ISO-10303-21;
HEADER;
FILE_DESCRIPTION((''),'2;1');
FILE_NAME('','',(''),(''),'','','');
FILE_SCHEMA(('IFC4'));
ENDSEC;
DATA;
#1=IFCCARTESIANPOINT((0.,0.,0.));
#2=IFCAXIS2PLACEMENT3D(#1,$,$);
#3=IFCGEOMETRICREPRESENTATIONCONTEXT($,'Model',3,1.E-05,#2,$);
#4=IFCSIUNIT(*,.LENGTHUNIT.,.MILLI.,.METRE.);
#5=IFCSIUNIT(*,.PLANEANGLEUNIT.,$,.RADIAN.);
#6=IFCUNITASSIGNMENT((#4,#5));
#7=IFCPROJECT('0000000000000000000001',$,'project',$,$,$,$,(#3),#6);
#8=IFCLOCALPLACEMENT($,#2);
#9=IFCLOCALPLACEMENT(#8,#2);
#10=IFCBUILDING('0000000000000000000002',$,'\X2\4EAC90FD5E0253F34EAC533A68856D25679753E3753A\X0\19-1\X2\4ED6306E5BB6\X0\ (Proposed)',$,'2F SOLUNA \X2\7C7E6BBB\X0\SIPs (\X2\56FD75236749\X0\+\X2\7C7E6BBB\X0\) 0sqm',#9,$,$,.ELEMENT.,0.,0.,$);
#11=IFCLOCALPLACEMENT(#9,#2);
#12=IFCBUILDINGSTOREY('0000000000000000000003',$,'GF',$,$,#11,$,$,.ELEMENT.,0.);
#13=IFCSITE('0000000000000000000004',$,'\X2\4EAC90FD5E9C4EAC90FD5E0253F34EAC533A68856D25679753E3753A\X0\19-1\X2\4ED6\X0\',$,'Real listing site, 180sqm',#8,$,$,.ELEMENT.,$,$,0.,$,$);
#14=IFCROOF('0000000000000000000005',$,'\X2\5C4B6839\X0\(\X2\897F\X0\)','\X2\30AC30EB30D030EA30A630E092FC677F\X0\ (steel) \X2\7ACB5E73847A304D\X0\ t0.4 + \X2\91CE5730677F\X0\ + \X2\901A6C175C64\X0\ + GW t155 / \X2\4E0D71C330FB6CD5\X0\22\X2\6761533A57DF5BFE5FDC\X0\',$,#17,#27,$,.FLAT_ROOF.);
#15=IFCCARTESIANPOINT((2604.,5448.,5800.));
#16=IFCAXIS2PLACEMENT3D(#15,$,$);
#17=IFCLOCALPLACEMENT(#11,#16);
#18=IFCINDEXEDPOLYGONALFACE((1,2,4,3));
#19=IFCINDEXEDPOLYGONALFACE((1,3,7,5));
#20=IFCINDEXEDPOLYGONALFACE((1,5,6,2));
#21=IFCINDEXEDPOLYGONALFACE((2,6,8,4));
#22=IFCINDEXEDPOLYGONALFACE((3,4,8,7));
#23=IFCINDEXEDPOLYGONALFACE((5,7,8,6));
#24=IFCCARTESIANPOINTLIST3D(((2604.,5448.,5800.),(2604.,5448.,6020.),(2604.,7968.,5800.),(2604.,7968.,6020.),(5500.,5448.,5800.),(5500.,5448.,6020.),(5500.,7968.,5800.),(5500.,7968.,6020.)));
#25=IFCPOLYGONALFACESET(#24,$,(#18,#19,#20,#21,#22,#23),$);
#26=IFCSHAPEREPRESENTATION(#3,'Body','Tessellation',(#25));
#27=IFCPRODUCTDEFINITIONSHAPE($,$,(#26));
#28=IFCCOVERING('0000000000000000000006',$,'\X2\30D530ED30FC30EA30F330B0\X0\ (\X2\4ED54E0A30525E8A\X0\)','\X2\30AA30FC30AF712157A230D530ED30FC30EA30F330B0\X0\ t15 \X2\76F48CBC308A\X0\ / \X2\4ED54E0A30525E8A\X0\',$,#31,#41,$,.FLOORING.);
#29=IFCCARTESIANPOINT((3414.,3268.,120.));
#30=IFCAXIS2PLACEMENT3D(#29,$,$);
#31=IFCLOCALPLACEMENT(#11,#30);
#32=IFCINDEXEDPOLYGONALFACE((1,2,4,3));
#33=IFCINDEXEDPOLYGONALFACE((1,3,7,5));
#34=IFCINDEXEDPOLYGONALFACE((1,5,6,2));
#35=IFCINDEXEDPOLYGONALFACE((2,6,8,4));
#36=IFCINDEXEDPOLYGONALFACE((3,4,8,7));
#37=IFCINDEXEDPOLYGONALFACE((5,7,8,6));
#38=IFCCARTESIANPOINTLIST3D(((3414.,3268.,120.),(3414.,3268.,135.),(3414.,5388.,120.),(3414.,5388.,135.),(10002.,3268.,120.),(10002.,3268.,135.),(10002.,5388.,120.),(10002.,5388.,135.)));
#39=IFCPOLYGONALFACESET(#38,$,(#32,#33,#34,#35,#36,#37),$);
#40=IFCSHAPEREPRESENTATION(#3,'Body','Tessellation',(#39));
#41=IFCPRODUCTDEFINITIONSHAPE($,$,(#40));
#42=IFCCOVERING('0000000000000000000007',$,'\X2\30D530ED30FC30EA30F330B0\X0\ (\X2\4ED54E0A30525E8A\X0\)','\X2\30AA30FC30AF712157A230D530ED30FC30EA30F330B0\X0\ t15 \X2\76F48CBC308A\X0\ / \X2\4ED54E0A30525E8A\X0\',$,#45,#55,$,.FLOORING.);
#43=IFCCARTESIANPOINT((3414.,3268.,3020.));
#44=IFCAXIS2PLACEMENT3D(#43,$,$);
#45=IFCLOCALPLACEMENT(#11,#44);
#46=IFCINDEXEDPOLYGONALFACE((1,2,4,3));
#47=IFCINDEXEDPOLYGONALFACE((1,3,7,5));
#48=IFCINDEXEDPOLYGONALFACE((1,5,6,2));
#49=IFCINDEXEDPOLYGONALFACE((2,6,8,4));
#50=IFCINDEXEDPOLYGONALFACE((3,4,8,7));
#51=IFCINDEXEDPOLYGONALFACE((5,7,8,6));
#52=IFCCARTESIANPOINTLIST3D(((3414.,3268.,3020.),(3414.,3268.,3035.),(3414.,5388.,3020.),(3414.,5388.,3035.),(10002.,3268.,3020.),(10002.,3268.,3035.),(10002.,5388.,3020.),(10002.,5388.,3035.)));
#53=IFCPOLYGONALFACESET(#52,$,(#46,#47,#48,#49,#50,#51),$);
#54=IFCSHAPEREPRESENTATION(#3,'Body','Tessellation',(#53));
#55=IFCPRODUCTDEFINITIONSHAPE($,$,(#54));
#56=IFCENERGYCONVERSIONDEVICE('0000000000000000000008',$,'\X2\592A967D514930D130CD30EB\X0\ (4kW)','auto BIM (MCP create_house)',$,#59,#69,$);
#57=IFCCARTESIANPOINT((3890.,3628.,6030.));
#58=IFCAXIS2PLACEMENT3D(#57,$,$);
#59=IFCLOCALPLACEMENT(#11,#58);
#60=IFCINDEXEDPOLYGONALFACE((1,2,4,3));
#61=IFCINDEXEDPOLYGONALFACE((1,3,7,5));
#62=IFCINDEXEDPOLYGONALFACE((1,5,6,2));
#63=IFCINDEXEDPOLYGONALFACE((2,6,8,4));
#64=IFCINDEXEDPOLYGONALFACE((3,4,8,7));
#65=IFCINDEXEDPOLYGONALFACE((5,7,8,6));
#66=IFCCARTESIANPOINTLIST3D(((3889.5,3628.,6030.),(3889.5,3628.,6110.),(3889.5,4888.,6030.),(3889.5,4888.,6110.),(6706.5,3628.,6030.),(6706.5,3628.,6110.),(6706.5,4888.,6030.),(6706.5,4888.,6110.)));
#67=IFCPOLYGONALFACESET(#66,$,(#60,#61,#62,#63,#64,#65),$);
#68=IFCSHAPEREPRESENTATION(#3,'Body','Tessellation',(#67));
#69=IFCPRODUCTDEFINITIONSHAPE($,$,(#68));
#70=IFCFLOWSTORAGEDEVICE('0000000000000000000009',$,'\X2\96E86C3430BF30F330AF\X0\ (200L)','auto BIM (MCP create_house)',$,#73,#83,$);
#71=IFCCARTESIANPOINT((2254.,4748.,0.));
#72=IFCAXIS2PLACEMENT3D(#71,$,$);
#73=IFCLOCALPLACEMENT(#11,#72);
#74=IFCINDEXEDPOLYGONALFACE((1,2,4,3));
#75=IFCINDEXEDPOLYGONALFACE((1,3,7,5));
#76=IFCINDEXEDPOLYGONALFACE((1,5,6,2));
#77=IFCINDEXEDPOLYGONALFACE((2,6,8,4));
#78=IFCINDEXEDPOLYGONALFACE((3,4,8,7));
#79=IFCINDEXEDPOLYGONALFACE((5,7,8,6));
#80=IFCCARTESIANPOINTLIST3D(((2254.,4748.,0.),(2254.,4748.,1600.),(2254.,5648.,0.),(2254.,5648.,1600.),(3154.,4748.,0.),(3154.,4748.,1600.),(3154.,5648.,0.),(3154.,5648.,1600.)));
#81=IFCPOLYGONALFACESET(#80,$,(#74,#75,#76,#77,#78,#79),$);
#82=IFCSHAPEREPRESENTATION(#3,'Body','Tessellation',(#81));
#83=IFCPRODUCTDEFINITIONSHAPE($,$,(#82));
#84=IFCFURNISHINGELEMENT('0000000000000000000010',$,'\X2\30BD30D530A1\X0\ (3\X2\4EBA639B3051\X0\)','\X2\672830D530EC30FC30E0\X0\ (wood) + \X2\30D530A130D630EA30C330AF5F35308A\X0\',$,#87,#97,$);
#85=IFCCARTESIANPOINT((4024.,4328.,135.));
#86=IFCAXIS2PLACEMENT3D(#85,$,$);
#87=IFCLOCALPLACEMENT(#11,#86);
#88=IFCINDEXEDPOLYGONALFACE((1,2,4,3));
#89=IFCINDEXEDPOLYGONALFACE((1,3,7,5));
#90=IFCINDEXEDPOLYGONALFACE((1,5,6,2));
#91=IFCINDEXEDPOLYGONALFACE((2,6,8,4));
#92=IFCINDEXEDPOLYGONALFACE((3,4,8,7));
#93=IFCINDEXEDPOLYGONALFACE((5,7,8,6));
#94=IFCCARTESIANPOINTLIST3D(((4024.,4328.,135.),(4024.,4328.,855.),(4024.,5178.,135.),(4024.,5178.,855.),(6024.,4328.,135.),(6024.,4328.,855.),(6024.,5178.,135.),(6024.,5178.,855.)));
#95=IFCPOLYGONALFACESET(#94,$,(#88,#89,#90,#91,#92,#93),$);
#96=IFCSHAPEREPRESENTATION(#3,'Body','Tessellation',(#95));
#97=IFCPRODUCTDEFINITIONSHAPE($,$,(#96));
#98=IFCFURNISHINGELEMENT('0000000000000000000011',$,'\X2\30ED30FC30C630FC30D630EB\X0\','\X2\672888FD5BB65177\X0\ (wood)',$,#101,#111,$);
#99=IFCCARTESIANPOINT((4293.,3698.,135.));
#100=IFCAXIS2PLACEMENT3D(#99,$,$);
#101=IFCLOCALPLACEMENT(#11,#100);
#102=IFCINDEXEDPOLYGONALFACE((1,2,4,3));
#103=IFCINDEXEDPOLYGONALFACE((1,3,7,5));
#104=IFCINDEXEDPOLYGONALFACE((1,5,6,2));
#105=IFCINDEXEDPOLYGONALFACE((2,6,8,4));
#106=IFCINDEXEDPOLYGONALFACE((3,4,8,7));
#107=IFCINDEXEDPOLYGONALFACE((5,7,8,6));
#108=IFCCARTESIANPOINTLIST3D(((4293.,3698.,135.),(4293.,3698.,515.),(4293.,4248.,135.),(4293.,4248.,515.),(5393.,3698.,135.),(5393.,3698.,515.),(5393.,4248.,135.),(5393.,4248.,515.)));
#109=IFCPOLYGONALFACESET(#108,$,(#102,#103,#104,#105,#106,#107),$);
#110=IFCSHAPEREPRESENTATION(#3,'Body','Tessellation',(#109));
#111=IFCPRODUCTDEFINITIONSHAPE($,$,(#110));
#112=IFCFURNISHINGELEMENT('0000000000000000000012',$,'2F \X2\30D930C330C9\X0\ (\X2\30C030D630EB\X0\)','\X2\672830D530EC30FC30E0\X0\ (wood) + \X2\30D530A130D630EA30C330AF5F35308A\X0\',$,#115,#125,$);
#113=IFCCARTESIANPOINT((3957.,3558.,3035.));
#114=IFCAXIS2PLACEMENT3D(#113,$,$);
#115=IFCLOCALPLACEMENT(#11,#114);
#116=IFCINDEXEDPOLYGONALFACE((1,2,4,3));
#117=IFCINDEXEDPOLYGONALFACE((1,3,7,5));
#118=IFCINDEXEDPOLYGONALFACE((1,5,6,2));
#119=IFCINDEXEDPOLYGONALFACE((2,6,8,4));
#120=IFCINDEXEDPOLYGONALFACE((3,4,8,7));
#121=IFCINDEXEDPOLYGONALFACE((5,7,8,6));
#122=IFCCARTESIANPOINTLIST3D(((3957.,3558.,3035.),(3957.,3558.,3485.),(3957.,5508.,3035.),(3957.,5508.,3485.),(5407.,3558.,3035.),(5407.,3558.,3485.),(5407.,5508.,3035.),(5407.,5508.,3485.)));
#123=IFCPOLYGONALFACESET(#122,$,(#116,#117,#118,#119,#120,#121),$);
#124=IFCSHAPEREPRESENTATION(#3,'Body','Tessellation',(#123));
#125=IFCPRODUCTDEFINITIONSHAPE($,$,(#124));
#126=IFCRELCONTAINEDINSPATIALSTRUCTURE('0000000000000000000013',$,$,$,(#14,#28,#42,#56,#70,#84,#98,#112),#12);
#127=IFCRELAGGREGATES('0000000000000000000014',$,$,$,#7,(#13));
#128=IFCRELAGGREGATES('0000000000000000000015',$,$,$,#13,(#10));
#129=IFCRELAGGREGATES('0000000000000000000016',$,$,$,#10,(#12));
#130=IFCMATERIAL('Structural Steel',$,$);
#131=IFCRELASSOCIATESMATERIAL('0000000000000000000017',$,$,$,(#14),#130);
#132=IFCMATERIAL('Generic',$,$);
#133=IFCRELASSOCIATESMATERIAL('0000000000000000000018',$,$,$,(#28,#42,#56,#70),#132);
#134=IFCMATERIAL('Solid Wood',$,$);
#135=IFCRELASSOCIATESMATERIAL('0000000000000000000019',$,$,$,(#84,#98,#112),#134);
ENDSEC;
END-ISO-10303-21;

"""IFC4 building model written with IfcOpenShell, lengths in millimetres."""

from ifc_helpers import new_model, si_unit, frame, frame_2d, origin, place, context, project, spatial, rectangle, extrude, material, element, save


model = new_model("IFC4")

# Units and contexts
model_context = context("Model", 3, precision=1e-05, world=origin())
ifc_project = project(units=[si_unit("LENGTHUNIT", "METRE", prefix="MILLI"), si_unit("PLANEANGLEUNIT", "RADIAN")], contexts=[model_context])

# Site, building, storey
site_placement = place(None, origin())
site = spatial("IfcSite", under=ifc_project, at=site_placement, Name="京都府京都市右京区梅津林口町19-1他", ObjectType="Real listing site, 180sqm", CompositionType="ELEMENT", RefElevation=0.0)
building_placement = place(site_placement, origin())
building = spatial("IfcBuilding", under=site, at=building_placement, Name="京都市右京区梅津林口町19-1他の家 (Proposed)", ObjectType="2F SOLUNA 籾殻SIPs (国産杉+籾殻) 0sqm", CompositionType="ELEMENT", ElevationOfRefHeight=0.0, ElevationOfTerrain=0.0)
storey_placement = place(building_placement, origin())
storey = spatial("IfcBuildingStorey", under=building, at=storey_placement, Name="GF", CompositionType="ELEMENT", Elevation=0.0)

# Shared definitions
ifc_material_1 = material(Name="Solid Wood")

# Roof
ifc_material_2 = material(Name="Structural Steel")
roof_1_placement = place(storey_placement, frame((2604.0, 5448.0, 5800.0)))
element("IfcRoof", 1, at=roof_1_placement, inside=storey, material=ifc_material_2, Name="屋根(西)", Description="ガルバリウム鋼板 (steel) 立平葺き t0.4 + 野地板 + 通気層 + GW t155 / 不燃・法22条区域対応", PredefinedType="FLAT_ROOF", context=model_context, shape_type="SweptSolid", body=[
    extrude(rectangle(XDim=2896.0, YDim=2520.0, at=frame_2d((1448.0, 1260.0))), frame((2604.0, 5448.0, 5800.0)), (0.0, 0.0, 1.0), 220.0),
])

# Coverings
ifc_material_3 = material(Name="Generic")
covering_1_placement = place(storey_placement, frame((3414.0, 3268.0, 120.0)))
element("IfcCovering", 2, at=covering_1_placement, inside=storey, material=ifc_material_3, Name="フローリング (仕上げ床)", Description="オーク無垢フローリング t15 直貼り / 仕上げ床", PredefinedType="FLOORING", context=model_context, shape_type="SweptSolid", body=[
    extrude(rectangle(XDim=6588.0, YDim=2120.0, at=frame_2d((3294.0, 1060.0))), frame((3414.0, 3268.0, 120.0)), (0.0, 0.0, 1.0), 15.0),
])
covering_2_placement = place(storey_placement, frame((3414.0, 3268.0, 3020.0)))
element("IfcCovering", 3, at=covering_2_placement, inside=storey, material=ifc_material_3, Name="フローリング (仕上げ床)", Description="オーク無垢フローリング t15 直貼り / 仕上げ床", PredefinedType="FLOORING", context=model_context, shape_type="SweptSolid", body=[
    extrude(rectangle(XDim=6588.0, YDim=2120.0, at=frame_2d((3294.0, 1060.0))), frame((3414.0, 3268.0, 3020.0)), (0.0, 0.0, 1.0), 15.0),
])

# Energy conversion device
energy_conversion_device_placement = place(storey_placement, frame((3890.0, 3628.0, 6030.0)))
element("IfcEnergyConversionDevice", 4, at=energy_conversion_device_placement, inside=storey, material=ifc_material_3, Name="太陽光パネル (4kW)", Description="auto BIM (MCP create_house)", context=model_context, shape_type="SweptSolid", body=[
    extrude(rectangle(XDim=2817.0, YDim=1260.0, at=frame_2d((1408.0, 630.0))), frame((3890.0, 3628.0, 6030.0)), (0.0, 0.0, 1.0), 80.0),
])

# Flow storage device
flow_storage_device_placement = place(storey_placement, frame((2254.0, 4748.0, 0.0)))
element("IfcFlowStorageDevice", 5, at=flow_storage_device_placement, inside=storey, material=ifc_material_3, Name="雨水タンク (200L)", Description="auto BIM (MCP create_house)", context=model_context, shape_type="SweptSolid", body=[
    extrude(rectangle(XDim=900.0, YDim=900.0, at=frame_2d((450.0, 450.0))), frame((2254.0, 4748.0, 0.0)), (0.0, 0.0, 1.0), 1600.0),
])

# Furnishing elements
furnishing_1_placement = place(storey_placement, frame((4024.0, 4328.0, 135.0)))
element("IfcFurnishingElement", 6, at=furnishing_1_placement, inside=storey, material=ifc_material_1, Name="ソファ (3人掛け)", Description="木フレーム (wood) + ファブリック張り", context=model_context, shape_type="SweptSolid", body=[
    extrude(rectangle(XDim=2000.0, YDim=850.0, at=frame_2d((1000.0, 425.0))), frame((4024.0, 4328.0, 135.0)), (0.0, 0.0, 1.0), 720.0),
])
furnishing_2_placement = place(storey_placement, frame((4293.0, 3698.0, 135.0)))
element("IfcFurnishingElement", 7, at=furnishing_2_placement, inside=storey, material=ifc_material_1, Name="ローテーブル", Description="木製家具 (wood)", context=model_context, shape_type="SweptSolid", body=[
    extrude(rectangle(XDim=1100.0, YDim=550.0, at=frame_2d((550.0, 275.0))), frame((4293.0, 3698.0, 135.0)), (0.0, 0.0, 1.0), 380.0),
])
furnishing_3_placement = place(storey_placement, frame((3957.0, 3558.0, 3035.0)))
element("IfcFurnishingElement", 8, at=furnishing_3_placement, inside=storey, material=ifc_material_1, Name="2F ベッド (ダブル)", Description="木フレーム (wood) + ファブリック張り", context=model_context, shape_type="SweptSolid", body=[
    extrude(rectangle(XDim=1450.0, YDim=1950.0, at=frame_2d((725.0, 975.0))), frame((3957.0, 3558.0, 3035.0)), (0.0, 0.0, 1.0), 450.0),
])

save(model, "model.ifc")
